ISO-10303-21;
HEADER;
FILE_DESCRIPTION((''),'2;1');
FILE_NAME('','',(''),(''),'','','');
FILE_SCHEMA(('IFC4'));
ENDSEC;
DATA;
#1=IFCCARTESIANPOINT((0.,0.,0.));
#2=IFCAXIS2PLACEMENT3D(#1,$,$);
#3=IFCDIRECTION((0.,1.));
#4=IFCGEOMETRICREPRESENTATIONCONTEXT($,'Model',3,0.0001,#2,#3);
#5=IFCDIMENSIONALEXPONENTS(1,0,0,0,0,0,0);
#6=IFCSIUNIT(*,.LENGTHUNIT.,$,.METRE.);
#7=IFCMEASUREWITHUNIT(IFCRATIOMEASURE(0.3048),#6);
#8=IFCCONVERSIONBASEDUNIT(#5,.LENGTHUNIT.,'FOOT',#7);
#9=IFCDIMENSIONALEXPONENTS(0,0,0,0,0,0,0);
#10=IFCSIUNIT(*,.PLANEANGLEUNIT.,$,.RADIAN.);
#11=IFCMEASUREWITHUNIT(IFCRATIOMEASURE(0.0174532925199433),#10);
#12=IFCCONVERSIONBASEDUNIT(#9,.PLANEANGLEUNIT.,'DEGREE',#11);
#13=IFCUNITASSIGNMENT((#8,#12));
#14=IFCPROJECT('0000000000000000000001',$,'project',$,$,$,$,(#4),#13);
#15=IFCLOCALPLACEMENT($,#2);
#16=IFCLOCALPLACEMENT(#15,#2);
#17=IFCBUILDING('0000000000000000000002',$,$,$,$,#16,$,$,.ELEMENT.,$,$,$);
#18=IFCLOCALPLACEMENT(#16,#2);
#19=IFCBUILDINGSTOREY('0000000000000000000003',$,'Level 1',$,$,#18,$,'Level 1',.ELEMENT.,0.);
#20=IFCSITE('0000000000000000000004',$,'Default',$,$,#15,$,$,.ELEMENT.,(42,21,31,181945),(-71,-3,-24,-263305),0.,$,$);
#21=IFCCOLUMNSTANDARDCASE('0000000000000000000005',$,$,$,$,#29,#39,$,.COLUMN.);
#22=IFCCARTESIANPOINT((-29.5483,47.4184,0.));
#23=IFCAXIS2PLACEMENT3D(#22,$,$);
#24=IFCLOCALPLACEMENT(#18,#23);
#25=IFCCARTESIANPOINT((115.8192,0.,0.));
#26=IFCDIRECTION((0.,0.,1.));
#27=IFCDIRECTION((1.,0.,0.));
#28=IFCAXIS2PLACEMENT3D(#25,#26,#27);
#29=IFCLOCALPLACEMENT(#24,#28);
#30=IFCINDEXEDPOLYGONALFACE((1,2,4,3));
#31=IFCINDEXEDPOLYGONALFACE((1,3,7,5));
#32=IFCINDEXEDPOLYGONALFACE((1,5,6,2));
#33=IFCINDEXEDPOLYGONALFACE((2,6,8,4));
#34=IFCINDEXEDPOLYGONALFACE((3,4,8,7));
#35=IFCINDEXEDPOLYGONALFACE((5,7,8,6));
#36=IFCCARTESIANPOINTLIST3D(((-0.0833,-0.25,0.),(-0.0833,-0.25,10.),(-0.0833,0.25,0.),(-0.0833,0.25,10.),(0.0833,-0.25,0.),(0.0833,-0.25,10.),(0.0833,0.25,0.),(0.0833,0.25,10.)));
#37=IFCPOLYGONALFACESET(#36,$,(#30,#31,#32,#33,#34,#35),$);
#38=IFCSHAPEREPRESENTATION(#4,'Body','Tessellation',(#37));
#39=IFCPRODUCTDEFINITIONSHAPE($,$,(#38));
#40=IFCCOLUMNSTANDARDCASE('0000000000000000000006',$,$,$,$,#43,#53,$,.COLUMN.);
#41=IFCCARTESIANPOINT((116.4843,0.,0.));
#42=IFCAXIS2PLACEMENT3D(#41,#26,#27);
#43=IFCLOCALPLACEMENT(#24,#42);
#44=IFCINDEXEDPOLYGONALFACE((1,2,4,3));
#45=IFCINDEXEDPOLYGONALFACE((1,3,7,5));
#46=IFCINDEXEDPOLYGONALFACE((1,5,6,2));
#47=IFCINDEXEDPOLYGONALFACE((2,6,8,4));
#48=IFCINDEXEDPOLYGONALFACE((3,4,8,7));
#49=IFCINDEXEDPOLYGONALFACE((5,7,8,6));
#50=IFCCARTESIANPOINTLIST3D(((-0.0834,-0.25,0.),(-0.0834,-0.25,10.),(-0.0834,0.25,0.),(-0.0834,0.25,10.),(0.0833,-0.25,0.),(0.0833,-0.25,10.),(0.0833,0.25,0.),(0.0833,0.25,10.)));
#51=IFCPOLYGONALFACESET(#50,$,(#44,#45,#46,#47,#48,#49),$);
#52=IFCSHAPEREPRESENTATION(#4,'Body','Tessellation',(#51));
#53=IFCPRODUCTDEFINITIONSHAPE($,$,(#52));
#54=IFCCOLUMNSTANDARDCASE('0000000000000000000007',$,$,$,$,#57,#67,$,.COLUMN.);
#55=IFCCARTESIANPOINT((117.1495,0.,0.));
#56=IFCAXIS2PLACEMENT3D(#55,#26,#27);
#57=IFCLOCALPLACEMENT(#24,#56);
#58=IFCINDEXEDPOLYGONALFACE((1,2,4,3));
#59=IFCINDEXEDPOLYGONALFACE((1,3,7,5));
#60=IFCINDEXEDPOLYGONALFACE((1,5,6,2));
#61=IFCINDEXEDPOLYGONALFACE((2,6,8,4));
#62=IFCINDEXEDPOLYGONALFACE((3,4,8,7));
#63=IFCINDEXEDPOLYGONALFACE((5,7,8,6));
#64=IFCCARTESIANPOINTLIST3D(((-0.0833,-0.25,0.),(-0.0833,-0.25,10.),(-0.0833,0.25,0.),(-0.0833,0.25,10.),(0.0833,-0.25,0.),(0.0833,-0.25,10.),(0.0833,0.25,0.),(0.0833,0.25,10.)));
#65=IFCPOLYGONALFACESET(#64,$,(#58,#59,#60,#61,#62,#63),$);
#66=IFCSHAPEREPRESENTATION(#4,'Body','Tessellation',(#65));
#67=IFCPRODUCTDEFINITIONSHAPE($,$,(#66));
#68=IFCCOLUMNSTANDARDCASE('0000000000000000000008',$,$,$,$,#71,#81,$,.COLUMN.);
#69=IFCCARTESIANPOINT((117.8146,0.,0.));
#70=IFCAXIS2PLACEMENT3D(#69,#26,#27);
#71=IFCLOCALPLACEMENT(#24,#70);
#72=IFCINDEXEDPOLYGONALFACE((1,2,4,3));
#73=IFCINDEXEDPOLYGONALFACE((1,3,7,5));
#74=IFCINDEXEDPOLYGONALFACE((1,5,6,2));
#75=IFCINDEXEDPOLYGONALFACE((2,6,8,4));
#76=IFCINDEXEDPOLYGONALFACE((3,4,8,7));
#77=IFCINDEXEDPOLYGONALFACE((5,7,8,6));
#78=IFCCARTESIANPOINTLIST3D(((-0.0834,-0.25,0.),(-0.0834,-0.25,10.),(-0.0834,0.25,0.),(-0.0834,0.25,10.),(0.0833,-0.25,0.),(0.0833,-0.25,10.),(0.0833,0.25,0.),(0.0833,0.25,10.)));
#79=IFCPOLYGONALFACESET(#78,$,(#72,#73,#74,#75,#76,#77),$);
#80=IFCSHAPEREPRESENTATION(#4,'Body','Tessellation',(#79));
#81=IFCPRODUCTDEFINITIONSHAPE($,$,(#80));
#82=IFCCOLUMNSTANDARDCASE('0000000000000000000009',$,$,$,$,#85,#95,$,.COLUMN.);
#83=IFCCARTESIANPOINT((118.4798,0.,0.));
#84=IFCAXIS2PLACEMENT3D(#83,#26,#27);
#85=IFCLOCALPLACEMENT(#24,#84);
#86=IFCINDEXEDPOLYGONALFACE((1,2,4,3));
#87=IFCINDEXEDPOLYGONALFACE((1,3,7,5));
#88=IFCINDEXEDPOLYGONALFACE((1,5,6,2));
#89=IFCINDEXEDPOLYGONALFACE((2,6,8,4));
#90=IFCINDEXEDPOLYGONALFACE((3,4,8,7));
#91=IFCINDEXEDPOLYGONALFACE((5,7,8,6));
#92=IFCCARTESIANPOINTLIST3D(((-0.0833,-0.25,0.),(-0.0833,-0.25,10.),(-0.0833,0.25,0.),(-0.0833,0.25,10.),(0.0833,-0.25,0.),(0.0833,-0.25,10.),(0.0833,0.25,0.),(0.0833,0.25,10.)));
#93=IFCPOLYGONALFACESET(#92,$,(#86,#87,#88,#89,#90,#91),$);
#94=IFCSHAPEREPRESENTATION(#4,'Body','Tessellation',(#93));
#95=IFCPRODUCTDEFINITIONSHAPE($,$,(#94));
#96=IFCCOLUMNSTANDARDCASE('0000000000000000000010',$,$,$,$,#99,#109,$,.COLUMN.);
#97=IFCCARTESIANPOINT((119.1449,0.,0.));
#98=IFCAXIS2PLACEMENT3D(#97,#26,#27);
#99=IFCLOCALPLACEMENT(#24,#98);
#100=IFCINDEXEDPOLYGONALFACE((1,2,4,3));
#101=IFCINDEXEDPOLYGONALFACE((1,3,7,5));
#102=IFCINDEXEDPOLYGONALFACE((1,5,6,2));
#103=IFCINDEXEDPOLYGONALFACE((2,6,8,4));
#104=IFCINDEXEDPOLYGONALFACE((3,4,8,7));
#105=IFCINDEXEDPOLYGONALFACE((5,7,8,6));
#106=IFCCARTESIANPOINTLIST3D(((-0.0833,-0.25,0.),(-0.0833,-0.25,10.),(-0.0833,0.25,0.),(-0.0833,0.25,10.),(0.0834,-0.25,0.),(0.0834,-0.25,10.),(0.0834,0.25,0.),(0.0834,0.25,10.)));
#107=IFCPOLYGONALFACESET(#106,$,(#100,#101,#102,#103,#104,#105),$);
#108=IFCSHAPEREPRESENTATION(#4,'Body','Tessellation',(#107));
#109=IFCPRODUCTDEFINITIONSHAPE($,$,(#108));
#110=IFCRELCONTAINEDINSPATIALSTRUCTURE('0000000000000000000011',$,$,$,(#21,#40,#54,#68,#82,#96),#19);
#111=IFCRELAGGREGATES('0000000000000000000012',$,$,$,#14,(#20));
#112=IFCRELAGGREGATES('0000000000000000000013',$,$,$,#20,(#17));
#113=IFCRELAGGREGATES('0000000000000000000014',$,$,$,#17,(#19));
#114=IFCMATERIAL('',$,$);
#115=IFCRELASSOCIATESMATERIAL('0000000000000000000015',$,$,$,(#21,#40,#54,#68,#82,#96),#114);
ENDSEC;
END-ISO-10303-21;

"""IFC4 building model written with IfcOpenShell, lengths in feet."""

from ifc_helpers import new_model, entity, si_unit, converted_unit, direction, frame, origin, place, context, project, spatial, rectangle, extrude, material, element, save


model = new_model("IFC4")

# Units and contexts
model_context = context("Model", 3, precision=0.0001, world=origin(), true_north=direction((0.0, 1.0)))
ifc_project = project(units=[converted_unit("LENGTHUNIT", "FOOT", entity("IfcRatioMeasure", 0.3048), si_unit("LENGTHUNIT", "METRE"), dimensions=[1, 0, 0, 0, 0, 0, 0]), converted_unit("PLANEANGLEUNIT", "DEGREE", entity("IfcRatioMeasure", 0.0174532925199433), si_unit("PLANEANGLEUNIT", "RADIAN"), dimensions=[0, 0, 0, 0, 0, 0, 0])], contexts=[model_context])

# Site, building, storey
site_placement = place(None, origin())
site = spatial("IfcSite", under=ifc_project, at=site_placement, Name="Default", CompositionType="ELEMENT", RefLatitude=(42, 21, 31, 181945), RefLongitude=(-71, -3, -24, -263305), RefElevation=0.0)
building_placement = place(site_placement, origin())
building = spatial("IfcBuilding", under=site, at=building_placement, CompositionType="ELEMENT")
storey_placement = place(building_placement, origin())
storey = spatial("IfcBuildingStorey", under=building, at=storey_placement, Name="Level 1", LongName="Level 1", CompositionType="ELEMENT", Elevation=0.0)

# Columns
ifc_material = material(Name="")
placement_1 = place(storey_placement, frame((-29.5483, 47.4184, 0.0)))
for number, where, z_axis, x_axis in (
    (1, (115.8192, 0.0, 0.0), (0.0, 0.0, 1.0), (1.0, 0.0, 0.0)),
    (2, (116.4843, 0.0, 0.0), (0.0, 0.0, 1.0), (1.0, 0.0, 0.0)),
    (3, (117.1495, 0.0, 0.0), (0.0, 0.0, 1.0), (1.0, 0.0, 0.0)),
    (4, (117.8146, 0.0, 0.0), (0.0, 0.0, 1.0), (1.0, 0.0, 0.0)),
    (5, (118.4798, 0.0, 0.0), (0.0, 0.0, 1.0), (1.0, 0.0, 0.0)),
    (6, (119.1449, 0.0, 0.0), (0.0, 0.0, 1.0), (1.0, 0.0, 0.0)),
):
    element("IfcColumnStandardCase", number, at=place(placement_1, frame(where, z_axis=z_axis, x_axis=x_axis)), inside=storey, material=ifc_material, PredefinedType="COLUMN", context=model_context, shape_type="SweptSolid", body=[
        extrude(rectangle(XDim=0.1667, YDim=0.5), origin(), (0.0, 0.0, 1.0), 10.0),
    ])

save(model, "model.ifc")
